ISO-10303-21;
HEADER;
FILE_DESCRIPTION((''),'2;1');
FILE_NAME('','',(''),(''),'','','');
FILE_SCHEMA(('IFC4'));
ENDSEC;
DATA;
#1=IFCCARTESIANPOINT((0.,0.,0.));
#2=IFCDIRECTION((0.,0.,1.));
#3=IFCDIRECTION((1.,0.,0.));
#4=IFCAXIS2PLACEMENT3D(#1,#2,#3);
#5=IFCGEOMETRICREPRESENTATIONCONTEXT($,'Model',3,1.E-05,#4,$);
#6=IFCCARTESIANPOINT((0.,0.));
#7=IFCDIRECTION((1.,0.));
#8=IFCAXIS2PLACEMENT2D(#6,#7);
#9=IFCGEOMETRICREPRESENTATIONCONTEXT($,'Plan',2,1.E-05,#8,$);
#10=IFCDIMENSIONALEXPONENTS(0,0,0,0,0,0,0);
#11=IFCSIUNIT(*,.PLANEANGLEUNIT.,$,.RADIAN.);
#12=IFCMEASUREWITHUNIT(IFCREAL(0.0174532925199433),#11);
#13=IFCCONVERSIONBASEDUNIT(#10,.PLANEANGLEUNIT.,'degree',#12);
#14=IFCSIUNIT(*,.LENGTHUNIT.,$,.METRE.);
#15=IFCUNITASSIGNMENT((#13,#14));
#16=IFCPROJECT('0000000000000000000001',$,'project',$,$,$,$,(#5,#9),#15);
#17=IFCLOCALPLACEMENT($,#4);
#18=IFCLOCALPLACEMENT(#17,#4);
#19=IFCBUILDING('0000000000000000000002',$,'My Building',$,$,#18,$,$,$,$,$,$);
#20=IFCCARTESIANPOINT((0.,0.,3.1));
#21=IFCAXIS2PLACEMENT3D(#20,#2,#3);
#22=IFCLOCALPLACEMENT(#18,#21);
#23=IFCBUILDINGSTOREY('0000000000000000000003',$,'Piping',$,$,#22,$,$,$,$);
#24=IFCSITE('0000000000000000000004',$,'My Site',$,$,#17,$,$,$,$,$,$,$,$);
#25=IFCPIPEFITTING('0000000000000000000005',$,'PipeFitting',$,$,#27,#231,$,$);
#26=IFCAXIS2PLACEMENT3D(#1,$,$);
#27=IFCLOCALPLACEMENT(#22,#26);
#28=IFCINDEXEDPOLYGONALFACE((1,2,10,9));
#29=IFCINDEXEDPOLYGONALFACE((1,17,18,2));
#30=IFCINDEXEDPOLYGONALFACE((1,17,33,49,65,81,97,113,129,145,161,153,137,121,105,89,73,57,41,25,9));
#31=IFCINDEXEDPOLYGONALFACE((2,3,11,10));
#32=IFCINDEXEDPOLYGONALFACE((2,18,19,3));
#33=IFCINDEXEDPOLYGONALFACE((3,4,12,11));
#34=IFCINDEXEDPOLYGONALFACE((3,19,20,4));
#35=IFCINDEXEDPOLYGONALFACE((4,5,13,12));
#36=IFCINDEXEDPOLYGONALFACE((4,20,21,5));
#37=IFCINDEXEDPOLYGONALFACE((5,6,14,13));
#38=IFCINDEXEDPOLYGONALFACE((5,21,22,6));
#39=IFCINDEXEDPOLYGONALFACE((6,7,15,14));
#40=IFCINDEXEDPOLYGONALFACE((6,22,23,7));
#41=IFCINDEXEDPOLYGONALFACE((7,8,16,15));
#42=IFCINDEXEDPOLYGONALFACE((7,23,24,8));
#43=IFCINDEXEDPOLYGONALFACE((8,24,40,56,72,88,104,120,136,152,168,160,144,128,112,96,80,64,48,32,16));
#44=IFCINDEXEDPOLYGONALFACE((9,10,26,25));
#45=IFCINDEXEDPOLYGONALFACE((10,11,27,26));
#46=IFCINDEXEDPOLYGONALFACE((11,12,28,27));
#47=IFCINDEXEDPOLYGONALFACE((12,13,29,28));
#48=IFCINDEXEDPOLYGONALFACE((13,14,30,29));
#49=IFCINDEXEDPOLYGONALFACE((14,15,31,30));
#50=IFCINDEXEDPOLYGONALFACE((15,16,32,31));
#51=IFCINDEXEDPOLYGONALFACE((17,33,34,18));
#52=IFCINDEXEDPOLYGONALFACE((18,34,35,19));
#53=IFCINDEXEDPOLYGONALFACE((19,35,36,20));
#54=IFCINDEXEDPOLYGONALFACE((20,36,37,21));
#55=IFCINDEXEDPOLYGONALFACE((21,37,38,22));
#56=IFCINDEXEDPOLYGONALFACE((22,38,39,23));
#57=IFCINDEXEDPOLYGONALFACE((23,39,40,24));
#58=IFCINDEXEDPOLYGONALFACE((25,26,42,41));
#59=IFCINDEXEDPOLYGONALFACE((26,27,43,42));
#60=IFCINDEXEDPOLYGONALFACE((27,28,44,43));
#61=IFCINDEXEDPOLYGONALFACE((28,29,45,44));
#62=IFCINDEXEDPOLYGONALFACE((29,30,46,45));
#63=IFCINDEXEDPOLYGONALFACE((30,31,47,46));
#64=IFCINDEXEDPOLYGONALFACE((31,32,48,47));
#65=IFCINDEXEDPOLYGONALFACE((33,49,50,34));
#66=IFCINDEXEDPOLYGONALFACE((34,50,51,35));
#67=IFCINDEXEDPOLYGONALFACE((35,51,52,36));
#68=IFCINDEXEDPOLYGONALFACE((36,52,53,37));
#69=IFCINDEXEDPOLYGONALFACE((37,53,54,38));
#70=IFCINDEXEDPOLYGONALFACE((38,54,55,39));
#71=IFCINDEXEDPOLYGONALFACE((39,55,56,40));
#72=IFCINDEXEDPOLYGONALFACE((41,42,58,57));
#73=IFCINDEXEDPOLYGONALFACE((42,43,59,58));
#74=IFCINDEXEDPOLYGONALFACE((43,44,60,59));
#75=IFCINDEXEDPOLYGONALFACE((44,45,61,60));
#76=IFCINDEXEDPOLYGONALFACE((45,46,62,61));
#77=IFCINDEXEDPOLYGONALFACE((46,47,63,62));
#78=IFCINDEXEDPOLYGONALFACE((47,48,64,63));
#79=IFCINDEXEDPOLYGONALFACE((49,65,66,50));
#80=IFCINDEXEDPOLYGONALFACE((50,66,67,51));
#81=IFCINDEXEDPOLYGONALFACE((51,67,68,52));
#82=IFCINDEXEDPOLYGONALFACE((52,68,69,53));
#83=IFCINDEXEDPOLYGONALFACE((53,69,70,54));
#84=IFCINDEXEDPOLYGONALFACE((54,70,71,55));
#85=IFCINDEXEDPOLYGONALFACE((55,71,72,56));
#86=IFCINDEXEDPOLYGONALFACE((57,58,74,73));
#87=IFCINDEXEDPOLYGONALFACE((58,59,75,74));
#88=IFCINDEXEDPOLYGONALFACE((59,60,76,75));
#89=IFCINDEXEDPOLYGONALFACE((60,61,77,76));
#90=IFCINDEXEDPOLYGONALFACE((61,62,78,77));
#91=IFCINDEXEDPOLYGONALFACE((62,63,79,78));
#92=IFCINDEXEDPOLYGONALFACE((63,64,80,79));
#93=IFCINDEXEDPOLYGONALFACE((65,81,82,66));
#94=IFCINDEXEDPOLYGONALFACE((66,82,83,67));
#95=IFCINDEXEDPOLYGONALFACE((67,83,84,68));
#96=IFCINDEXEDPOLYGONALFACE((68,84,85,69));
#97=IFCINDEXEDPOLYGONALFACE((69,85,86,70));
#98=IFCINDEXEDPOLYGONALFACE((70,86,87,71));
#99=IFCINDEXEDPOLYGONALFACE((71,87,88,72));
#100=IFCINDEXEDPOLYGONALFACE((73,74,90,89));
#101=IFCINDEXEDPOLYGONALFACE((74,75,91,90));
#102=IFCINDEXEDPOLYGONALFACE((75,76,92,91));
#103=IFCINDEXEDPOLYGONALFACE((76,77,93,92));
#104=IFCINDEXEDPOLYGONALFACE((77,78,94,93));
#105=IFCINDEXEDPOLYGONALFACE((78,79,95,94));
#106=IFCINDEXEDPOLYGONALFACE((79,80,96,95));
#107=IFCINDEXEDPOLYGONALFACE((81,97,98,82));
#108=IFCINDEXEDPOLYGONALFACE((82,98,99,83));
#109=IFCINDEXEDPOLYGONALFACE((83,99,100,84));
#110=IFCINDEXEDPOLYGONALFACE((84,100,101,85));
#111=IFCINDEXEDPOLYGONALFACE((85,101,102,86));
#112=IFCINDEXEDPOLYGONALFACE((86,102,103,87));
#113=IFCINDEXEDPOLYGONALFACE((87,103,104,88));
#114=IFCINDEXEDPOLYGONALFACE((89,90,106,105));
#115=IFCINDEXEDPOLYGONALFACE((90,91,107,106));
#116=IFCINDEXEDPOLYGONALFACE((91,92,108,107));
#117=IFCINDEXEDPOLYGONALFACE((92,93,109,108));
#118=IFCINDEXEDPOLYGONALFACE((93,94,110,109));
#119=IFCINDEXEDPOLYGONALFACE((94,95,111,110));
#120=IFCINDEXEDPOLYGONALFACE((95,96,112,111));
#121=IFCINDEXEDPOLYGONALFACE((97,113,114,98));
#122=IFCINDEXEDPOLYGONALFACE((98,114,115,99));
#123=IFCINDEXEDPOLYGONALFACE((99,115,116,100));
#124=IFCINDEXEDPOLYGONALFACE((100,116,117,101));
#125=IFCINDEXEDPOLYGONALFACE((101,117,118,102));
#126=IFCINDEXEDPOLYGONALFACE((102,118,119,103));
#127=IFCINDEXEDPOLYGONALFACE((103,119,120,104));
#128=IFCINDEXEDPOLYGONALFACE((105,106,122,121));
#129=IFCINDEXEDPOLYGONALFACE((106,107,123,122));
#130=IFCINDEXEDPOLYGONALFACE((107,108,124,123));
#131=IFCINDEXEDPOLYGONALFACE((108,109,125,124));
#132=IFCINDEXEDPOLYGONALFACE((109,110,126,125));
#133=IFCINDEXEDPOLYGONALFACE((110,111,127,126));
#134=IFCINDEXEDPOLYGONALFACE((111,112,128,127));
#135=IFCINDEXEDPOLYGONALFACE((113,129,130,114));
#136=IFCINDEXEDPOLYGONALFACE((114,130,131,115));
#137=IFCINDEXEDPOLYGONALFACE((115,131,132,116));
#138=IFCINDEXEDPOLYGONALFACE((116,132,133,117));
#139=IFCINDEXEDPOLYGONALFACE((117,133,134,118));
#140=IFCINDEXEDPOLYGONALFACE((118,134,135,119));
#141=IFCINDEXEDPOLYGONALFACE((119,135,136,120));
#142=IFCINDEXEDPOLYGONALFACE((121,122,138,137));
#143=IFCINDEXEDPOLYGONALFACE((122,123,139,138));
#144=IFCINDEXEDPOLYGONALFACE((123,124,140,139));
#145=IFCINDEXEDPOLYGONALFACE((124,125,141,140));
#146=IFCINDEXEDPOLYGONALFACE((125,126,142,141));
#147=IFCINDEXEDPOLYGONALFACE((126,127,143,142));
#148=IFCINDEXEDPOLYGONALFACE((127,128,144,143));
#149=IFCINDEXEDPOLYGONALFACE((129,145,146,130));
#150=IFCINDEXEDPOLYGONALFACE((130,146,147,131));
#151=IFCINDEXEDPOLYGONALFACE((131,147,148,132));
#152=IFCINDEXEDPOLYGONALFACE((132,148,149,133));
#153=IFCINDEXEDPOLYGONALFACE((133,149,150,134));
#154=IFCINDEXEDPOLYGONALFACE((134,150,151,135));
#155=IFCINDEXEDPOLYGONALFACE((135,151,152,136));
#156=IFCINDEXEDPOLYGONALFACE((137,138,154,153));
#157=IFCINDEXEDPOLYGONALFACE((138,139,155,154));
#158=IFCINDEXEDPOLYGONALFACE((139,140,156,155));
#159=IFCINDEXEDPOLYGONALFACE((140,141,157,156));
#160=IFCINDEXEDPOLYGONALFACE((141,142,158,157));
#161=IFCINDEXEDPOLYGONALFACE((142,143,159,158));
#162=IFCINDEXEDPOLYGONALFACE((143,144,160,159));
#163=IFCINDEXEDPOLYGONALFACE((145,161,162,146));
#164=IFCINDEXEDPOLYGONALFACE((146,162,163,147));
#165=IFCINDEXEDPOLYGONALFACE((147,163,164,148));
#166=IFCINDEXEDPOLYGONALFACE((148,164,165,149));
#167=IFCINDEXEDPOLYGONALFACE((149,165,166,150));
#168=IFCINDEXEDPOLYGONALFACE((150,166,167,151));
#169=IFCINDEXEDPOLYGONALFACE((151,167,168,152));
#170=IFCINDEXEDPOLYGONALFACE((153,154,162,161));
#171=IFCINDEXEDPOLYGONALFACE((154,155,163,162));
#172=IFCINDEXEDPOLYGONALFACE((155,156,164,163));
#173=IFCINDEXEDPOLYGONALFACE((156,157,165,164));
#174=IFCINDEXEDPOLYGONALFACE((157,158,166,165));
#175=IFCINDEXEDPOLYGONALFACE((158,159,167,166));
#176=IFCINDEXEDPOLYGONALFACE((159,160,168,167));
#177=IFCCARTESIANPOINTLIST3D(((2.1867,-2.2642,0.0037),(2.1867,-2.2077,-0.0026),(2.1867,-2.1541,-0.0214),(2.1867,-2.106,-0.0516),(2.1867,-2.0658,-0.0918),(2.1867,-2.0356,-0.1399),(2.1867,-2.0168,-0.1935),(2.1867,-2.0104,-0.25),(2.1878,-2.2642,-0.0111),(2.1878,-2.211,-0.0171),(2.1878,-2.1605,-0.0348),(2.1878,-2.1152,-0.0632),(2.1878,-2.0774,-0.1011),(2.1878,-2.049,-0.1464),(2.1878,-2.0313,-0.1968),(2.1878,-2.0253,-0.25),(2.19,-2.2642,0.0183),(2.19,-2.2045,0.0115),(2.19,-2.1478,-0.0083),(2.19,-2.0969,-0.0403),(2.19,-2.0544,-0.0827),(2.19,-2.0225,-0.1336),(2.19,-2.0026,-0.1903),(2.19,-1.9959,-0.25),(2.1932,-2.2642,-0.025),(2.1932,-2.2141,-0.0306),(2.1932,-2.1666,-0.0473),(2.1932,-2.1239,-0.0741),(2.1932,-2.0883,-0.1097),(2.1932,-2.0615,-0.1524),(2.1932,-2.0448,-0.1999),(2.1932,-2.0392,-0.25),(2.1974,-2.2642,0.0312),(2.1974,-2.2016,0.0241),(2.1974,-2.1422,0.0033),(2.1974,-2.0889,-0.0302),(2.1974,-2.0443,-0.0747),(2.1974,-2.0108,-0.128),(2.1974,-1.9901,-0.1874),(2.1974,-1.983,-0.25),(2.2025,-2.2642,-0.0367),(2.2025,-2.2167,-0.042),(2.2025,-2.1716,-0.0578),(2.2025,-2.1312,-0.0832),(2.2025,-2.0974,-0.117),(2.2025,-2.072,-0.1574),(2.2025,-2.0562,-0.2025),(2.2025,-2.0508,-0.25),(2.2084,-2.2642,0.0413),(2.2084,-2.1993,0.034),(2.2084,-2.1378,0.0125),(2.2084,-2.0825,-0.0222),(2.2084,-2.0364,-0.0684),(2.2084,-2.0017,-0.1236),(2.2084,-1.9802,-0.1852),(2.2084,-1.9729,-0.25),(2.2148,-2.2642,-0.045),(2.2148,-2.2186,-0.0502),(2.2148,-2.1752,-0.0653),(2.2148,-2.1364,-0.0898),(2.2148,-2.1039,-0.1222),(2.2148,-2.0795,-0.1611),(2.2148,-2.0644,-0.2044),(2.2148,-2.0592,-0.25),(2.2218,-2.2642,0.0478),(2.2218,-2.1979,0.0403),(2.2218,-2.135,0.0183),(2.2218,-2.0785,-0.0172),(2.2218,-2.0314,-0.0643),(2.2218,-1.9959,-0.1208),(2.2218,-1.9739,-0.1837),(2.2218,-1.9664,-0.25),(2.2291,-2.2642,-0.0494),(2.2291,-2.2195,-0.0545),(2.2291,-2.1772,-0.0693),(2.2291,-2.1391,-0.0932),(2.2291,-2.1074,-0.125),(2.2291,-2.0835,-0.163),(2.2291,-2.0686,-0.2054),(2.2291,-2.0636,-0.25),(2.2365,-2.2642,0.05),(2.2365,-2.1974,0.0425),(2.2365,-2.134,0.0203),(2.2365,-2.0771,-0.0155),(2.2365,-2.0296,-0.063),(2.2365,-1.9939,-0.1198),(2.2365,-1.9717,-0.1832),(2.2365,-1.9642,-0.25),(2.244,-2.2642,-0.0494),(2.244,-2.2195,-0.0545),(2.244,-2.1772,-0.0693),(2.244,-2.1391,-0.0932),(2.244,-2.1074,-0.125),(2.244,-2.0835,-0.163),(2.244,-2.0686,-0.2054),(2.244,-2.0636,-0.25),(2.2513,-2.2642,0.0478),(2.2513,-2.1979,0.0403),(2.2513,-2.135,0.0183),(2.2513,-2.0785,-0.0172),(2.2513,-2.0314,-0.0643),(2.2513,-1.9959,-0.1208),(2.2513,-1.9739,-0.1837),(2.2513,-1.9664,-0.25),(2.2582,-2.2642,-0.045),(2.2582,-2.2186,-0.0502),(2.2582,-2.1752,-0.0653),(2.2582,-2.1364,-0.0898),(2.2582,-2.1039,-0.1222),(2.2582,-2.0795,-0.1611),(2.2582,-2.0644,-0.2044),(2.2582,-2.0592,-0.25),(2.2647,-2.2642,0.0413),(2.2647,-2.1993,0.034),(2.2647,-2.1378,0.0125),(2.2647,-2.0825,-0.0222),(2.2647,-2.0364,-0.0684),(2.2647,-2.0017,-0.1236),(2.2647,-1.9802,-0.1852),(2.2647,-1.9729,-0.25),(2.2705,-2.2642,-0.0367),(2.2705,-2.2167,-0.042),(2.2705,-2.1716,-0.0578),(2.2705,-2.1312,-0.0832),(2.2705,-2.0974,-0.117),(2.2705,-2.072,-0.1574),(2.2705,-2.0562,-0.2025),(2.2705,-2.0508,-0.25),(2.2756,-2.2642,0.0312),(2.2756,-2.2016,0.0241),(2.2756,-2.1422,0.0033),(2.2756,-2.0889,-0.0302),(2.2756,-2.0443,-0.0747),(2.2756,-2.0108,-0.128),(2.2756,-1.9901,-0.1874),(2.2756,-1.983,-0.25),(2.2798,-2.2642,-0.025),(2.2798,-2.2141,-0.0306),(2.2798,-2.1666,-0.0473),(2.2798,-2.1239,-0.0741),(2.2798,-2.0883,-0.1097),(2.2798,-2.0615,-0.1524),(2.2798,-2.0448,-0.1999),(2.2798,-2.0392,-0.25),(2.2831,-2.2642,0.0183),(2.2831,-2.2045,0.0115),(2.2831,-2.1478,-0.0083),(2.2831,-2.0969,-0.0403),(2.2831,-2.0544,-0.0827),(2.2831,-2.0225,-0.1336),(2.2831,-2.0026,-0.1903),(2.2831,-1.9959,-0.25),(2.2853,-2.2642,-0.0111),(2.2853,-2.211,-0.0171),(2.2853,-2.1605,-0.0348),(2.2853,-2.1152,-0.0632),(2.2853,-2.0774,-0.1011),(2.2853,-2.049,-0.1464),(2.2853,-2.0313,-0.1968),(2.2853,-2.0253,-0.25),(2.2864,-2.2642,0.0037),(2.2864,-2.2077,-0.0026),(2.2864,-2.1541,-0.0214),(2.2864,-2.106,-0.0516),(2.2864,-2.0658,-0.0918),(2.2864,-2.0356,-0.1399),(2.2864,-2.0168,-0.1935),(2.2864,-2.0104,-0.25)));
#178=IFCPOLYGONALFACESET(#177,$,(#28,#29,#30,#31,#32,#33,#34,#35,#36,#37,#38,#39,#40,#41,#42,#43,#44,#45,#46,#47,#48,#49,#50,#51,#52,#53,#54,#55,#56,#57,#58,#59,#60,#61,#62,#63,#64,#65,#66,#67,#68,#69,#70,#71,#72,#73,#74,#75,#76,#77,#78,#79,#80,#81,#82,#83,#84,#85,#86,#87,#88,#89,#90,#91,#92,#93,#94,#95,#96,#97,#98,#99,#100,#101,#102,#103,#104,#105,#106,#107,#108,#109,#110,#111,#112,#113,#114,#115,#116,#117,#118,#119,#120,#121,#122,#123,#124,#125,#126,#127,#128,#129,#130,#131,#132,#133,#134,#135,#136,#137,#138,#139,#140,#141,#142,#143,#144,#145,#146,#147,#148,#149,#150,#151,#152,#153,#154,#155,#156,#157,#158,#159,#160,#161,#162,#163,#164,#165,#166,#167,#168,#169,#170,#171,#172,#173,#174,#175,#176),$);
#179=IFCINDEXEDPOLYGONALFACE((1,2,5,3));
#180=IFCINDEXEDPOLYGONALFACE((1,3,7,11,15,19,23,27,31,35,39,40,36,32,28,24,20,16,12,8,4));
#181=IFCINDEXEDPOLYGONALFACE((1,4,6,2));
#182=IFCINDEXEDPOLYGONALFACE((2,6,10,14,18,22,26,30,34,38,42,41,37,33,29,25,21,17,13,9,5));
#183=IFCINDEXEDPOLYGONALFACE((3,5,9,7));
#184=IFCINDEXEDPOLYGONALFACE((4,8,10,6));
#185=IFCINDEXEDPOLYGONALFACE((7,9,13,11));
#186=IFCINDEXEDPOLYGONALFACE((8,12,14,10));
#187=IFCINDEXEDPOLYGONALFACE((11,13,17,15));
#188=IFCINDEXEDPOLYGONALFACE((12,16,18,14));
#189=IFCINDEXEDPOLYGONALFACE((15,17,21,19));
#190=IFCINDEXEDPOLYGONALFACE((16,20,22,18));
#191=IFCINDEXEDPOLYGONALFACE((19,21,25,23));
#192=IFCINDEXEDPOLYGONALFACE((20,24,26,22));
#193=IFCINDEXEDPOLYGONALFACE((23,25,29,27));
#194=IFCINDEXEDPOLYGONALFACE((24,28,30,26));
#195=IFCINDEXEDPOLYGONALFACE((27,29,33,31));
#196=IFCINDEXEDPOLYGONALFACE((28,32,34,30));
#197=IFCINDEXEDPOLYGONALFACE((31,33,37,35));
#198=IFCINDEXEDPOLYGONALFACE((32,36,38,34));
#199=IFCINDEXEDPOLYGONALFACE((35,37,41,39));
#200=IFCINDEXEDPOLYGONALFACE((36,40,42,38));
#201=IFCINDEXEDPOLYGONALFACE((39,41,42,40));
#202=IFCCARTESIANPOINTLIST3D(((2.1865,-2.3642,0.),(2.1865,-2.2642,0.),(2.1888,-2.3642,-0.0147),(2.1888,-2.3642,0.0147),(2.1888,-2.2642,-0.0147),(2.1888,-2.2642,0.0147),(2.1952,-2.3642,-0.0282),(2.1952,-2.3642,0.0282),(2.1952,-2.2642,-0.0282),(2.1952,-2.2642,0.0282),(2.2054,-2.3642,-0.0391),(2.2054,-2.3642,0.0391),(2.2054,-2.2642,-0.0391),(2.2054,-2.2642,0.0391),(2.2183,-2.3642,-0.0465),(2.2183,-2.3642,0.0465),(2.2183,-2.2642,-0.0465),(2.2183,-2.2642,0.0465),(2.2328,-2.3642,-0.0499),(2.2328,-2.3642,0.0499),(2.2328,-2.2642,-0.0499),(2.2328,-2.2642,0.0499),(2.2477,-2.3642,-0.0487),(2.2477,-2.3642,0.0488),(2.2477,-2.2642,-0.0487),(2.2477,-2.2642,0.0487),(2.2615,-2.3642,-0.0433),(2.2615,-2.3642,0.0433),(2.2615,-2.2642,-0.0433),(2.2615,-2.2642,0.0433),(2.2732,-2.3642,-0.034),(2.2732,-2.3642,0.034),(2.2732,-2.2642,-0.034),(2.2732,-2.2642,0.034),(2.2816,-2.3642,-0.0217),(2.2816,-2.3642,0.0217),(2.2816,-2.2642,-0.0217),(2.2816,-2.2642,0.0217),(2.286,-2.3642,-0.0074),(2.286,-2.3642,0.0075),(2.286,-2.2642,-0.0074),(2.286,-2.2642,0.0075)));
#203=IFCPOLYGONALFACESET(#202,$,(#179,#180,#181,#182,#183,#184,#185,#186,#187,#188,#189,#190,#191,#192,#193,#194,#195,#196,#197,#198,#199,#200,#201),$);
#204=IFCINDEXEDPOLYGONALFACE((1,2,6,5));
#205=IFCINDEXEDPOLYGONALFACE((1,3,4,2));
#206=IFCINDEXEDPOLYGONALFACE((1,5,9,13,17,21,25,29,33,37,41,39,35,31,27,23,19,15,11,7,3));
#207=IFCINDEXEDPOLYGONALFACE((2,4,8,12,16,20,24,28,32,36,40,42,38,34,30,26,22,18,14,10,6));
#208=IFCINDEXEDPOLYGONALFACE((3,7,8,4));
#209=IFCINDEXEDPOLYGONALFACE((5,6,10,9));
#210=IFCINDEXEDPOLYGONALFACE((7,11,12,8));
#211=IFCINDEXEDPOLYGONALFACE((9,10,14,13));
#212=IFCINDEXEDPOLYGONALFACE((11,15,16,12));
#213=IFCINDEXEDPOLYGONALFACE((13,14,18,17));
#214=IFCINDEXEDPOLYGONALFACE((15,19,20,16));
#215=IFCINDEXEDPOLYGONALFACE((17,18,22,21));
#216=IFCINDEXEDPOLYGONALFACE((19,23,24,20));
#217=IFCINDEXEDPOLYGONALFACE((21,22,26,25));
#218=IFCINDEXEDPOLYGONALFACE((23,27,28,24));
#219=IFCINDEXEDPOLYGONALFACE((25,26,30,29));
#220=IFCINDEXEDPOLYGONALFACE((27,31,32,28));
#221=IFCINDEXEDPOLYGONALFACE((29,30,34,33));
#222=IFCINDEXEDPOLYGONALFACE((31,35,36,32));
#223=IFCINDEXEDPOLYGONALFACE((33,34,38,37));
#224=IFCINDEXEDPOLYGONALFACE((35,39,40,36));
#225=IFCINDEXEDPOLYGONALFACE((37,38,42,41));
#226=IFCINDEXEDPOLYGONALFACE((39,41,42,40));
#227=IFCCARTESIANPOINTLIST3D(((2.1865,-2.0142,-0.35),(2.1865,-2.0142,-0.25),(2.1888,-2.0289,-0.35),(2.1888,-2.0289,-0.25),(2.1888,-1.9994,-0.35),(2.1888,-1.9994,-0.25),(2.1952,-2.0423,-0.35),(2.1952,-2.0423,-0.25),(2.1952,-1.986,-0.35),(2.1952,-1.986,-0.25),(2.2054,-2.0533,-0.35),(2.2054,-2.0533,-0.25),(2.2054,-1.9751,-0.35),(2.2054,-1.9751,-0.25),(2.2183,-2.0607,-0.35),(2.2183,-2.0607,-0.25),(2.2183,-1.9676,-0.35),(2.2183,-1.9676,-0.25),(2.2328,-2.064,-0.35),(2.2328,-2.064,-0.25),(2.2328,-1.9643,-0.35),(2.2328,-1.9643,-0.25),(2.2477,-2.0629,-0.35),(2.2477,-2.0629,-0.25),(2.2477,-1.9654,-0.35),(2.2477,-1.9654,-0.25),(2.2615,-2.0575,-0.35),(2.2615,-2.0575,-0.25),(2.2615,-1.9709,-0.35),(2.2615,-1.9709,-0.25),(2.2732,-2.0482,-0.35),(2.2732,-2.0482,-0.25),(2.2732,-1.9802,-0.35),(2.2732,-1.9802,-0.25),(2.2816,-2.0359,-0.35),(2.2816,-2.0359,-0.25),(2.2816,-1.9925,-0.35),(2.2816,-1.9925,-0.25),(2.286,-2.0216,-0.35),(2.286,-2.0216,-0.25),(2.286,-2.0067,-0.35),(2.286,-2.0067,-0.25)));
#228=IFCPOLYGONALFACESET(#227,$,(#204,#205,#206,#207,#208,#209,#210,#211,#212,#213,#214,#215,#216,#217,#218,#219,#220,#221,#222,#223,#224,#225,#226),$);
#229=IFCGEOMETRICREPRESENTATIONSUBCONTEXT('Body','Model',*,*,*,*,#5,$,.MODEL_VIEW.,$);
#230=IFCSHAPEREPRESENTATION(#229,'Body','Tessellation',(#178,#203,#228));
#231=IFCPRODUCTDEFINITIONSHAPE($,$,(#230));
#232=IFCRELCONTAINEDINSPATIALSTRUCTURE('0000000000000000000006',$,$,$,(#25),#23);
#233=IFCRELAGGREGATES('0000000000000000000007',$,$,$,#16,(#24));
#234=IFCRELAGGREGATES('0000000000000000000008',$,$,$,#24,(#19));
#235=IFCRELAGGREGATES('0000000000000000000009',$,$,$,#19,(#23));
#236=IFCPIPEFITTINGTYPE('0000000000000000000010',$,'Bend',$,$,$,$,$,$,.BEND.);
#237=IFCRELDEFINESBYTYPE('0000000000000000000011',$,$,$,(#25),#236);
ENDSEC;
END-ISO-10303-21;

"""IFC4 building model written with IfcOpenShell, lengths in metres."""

from ifc_helpers import new_model, entity, si_unit, converted_unit, frame, origin_with_axes, origin_2d_with_axis, place, context, subcontext, project, spatial, circle, extrude, source, transform, mapped, type_object, type_shapes, element, save


model = new_model("IFC4")

# Units and contexts
model_context = context("Model", 3, precision=1e-05, world=origin_with_axes())
plan_context = context("Plan", 2, precision=1e-05, world=origin_2d_with_axis())
body_context = subcontext(model_context, "Body", "Model", "MODEL_VIEW")
ifc_project = project(units=[converted_unit("PLANEANGLEUNIT", "degree", entity("IfcReal", 0.0174532925199433), si_unit("PLANEANGLEUNIT", "RADIAN"), dimensions=[0, 0, 0, 0, 0, 0, 0]), si_unit("LENGTHUNIT", "METRE")], contexts=[model_context, plan_context])

# Site, building, storey
site_placement = place(None, origin_with_axes())
site = spatial("IfcSite", under=ifc_project, at=site_placement, Name="My Site")
building_placement = place(site_placement, origin_with_axes())
building = spatial("IfcBuilding", under=site, at=building_placement, Name="My Building")
storey_placement = place(building_placement, frame((0.0, 0.0, 3.1), z_axis=(0.0, 0.0, 1.0), x_axis=(1.0, 0.0, 0.0)))
storey = spatial("IfcBuildingStorey", under=building, at=storey_placement, Name="Piping")

# Pipe fitting
pipe_fitting_type_1 = type_object("IfcPipeFittingType", Name="Bend", PredefinedType="BEND")
shared_shape_1 = source(origin_with_axes(), body_context, "Body", "SolidModel", [
    entity("IfcSweptDiskSolid", entity("IfcIndexedPolyCurve", entity("IfcCartesianPointList3D", [[0.0, 0.0, 0.1], [0.0, -0.0732, 0.2768], [0.0, -0.25, 0.35]]), [entity("IfcArcIndex", [1, 2, 3])]), 0.05),
    extrude(circle(Radius=0.05), origin_with_axes(), (0.0, 0.0, 1.0), 0.1),
    extrude(circle(Radius=0.05), frame((0.0, -0.25, 0.35), z_axis=(0.0, -1.0, 0.000022), x_axis=(1.0, 0.0, 0.0)), (0.0, 0.0, 1.0), 0.1),
])
type_shapes(pipe_fitting_type_1, [shared_shape_1])
for number, where, z_axis, x_axis, name in (
    (1, (2.2365, -2.3642, 0.0), (0.0, 1.0, -0.000022), (-1.0, 0.0, 0.0), "PipeFitting"),
):
    element("IfcPipeFitting", number, at=place(storey_placement, frame(where, z_axis=z_axis, x_axis=x_axis)), inside=storey, type_object=pipe_fitting_type_1, Name=name, context=body_context, shape_type="MappedRepresentation", body=[
        mapped(shared_shape_1, transform((0.0, 0.0, 0.0), x_axis=(1.0, 0.0, 0.0), y_axis=(0.0, 1.0, 0.0), z_axis=(0.0, 0.0, 1.0), scale=1.0)),
    ])

save(model, "model.ifc")
